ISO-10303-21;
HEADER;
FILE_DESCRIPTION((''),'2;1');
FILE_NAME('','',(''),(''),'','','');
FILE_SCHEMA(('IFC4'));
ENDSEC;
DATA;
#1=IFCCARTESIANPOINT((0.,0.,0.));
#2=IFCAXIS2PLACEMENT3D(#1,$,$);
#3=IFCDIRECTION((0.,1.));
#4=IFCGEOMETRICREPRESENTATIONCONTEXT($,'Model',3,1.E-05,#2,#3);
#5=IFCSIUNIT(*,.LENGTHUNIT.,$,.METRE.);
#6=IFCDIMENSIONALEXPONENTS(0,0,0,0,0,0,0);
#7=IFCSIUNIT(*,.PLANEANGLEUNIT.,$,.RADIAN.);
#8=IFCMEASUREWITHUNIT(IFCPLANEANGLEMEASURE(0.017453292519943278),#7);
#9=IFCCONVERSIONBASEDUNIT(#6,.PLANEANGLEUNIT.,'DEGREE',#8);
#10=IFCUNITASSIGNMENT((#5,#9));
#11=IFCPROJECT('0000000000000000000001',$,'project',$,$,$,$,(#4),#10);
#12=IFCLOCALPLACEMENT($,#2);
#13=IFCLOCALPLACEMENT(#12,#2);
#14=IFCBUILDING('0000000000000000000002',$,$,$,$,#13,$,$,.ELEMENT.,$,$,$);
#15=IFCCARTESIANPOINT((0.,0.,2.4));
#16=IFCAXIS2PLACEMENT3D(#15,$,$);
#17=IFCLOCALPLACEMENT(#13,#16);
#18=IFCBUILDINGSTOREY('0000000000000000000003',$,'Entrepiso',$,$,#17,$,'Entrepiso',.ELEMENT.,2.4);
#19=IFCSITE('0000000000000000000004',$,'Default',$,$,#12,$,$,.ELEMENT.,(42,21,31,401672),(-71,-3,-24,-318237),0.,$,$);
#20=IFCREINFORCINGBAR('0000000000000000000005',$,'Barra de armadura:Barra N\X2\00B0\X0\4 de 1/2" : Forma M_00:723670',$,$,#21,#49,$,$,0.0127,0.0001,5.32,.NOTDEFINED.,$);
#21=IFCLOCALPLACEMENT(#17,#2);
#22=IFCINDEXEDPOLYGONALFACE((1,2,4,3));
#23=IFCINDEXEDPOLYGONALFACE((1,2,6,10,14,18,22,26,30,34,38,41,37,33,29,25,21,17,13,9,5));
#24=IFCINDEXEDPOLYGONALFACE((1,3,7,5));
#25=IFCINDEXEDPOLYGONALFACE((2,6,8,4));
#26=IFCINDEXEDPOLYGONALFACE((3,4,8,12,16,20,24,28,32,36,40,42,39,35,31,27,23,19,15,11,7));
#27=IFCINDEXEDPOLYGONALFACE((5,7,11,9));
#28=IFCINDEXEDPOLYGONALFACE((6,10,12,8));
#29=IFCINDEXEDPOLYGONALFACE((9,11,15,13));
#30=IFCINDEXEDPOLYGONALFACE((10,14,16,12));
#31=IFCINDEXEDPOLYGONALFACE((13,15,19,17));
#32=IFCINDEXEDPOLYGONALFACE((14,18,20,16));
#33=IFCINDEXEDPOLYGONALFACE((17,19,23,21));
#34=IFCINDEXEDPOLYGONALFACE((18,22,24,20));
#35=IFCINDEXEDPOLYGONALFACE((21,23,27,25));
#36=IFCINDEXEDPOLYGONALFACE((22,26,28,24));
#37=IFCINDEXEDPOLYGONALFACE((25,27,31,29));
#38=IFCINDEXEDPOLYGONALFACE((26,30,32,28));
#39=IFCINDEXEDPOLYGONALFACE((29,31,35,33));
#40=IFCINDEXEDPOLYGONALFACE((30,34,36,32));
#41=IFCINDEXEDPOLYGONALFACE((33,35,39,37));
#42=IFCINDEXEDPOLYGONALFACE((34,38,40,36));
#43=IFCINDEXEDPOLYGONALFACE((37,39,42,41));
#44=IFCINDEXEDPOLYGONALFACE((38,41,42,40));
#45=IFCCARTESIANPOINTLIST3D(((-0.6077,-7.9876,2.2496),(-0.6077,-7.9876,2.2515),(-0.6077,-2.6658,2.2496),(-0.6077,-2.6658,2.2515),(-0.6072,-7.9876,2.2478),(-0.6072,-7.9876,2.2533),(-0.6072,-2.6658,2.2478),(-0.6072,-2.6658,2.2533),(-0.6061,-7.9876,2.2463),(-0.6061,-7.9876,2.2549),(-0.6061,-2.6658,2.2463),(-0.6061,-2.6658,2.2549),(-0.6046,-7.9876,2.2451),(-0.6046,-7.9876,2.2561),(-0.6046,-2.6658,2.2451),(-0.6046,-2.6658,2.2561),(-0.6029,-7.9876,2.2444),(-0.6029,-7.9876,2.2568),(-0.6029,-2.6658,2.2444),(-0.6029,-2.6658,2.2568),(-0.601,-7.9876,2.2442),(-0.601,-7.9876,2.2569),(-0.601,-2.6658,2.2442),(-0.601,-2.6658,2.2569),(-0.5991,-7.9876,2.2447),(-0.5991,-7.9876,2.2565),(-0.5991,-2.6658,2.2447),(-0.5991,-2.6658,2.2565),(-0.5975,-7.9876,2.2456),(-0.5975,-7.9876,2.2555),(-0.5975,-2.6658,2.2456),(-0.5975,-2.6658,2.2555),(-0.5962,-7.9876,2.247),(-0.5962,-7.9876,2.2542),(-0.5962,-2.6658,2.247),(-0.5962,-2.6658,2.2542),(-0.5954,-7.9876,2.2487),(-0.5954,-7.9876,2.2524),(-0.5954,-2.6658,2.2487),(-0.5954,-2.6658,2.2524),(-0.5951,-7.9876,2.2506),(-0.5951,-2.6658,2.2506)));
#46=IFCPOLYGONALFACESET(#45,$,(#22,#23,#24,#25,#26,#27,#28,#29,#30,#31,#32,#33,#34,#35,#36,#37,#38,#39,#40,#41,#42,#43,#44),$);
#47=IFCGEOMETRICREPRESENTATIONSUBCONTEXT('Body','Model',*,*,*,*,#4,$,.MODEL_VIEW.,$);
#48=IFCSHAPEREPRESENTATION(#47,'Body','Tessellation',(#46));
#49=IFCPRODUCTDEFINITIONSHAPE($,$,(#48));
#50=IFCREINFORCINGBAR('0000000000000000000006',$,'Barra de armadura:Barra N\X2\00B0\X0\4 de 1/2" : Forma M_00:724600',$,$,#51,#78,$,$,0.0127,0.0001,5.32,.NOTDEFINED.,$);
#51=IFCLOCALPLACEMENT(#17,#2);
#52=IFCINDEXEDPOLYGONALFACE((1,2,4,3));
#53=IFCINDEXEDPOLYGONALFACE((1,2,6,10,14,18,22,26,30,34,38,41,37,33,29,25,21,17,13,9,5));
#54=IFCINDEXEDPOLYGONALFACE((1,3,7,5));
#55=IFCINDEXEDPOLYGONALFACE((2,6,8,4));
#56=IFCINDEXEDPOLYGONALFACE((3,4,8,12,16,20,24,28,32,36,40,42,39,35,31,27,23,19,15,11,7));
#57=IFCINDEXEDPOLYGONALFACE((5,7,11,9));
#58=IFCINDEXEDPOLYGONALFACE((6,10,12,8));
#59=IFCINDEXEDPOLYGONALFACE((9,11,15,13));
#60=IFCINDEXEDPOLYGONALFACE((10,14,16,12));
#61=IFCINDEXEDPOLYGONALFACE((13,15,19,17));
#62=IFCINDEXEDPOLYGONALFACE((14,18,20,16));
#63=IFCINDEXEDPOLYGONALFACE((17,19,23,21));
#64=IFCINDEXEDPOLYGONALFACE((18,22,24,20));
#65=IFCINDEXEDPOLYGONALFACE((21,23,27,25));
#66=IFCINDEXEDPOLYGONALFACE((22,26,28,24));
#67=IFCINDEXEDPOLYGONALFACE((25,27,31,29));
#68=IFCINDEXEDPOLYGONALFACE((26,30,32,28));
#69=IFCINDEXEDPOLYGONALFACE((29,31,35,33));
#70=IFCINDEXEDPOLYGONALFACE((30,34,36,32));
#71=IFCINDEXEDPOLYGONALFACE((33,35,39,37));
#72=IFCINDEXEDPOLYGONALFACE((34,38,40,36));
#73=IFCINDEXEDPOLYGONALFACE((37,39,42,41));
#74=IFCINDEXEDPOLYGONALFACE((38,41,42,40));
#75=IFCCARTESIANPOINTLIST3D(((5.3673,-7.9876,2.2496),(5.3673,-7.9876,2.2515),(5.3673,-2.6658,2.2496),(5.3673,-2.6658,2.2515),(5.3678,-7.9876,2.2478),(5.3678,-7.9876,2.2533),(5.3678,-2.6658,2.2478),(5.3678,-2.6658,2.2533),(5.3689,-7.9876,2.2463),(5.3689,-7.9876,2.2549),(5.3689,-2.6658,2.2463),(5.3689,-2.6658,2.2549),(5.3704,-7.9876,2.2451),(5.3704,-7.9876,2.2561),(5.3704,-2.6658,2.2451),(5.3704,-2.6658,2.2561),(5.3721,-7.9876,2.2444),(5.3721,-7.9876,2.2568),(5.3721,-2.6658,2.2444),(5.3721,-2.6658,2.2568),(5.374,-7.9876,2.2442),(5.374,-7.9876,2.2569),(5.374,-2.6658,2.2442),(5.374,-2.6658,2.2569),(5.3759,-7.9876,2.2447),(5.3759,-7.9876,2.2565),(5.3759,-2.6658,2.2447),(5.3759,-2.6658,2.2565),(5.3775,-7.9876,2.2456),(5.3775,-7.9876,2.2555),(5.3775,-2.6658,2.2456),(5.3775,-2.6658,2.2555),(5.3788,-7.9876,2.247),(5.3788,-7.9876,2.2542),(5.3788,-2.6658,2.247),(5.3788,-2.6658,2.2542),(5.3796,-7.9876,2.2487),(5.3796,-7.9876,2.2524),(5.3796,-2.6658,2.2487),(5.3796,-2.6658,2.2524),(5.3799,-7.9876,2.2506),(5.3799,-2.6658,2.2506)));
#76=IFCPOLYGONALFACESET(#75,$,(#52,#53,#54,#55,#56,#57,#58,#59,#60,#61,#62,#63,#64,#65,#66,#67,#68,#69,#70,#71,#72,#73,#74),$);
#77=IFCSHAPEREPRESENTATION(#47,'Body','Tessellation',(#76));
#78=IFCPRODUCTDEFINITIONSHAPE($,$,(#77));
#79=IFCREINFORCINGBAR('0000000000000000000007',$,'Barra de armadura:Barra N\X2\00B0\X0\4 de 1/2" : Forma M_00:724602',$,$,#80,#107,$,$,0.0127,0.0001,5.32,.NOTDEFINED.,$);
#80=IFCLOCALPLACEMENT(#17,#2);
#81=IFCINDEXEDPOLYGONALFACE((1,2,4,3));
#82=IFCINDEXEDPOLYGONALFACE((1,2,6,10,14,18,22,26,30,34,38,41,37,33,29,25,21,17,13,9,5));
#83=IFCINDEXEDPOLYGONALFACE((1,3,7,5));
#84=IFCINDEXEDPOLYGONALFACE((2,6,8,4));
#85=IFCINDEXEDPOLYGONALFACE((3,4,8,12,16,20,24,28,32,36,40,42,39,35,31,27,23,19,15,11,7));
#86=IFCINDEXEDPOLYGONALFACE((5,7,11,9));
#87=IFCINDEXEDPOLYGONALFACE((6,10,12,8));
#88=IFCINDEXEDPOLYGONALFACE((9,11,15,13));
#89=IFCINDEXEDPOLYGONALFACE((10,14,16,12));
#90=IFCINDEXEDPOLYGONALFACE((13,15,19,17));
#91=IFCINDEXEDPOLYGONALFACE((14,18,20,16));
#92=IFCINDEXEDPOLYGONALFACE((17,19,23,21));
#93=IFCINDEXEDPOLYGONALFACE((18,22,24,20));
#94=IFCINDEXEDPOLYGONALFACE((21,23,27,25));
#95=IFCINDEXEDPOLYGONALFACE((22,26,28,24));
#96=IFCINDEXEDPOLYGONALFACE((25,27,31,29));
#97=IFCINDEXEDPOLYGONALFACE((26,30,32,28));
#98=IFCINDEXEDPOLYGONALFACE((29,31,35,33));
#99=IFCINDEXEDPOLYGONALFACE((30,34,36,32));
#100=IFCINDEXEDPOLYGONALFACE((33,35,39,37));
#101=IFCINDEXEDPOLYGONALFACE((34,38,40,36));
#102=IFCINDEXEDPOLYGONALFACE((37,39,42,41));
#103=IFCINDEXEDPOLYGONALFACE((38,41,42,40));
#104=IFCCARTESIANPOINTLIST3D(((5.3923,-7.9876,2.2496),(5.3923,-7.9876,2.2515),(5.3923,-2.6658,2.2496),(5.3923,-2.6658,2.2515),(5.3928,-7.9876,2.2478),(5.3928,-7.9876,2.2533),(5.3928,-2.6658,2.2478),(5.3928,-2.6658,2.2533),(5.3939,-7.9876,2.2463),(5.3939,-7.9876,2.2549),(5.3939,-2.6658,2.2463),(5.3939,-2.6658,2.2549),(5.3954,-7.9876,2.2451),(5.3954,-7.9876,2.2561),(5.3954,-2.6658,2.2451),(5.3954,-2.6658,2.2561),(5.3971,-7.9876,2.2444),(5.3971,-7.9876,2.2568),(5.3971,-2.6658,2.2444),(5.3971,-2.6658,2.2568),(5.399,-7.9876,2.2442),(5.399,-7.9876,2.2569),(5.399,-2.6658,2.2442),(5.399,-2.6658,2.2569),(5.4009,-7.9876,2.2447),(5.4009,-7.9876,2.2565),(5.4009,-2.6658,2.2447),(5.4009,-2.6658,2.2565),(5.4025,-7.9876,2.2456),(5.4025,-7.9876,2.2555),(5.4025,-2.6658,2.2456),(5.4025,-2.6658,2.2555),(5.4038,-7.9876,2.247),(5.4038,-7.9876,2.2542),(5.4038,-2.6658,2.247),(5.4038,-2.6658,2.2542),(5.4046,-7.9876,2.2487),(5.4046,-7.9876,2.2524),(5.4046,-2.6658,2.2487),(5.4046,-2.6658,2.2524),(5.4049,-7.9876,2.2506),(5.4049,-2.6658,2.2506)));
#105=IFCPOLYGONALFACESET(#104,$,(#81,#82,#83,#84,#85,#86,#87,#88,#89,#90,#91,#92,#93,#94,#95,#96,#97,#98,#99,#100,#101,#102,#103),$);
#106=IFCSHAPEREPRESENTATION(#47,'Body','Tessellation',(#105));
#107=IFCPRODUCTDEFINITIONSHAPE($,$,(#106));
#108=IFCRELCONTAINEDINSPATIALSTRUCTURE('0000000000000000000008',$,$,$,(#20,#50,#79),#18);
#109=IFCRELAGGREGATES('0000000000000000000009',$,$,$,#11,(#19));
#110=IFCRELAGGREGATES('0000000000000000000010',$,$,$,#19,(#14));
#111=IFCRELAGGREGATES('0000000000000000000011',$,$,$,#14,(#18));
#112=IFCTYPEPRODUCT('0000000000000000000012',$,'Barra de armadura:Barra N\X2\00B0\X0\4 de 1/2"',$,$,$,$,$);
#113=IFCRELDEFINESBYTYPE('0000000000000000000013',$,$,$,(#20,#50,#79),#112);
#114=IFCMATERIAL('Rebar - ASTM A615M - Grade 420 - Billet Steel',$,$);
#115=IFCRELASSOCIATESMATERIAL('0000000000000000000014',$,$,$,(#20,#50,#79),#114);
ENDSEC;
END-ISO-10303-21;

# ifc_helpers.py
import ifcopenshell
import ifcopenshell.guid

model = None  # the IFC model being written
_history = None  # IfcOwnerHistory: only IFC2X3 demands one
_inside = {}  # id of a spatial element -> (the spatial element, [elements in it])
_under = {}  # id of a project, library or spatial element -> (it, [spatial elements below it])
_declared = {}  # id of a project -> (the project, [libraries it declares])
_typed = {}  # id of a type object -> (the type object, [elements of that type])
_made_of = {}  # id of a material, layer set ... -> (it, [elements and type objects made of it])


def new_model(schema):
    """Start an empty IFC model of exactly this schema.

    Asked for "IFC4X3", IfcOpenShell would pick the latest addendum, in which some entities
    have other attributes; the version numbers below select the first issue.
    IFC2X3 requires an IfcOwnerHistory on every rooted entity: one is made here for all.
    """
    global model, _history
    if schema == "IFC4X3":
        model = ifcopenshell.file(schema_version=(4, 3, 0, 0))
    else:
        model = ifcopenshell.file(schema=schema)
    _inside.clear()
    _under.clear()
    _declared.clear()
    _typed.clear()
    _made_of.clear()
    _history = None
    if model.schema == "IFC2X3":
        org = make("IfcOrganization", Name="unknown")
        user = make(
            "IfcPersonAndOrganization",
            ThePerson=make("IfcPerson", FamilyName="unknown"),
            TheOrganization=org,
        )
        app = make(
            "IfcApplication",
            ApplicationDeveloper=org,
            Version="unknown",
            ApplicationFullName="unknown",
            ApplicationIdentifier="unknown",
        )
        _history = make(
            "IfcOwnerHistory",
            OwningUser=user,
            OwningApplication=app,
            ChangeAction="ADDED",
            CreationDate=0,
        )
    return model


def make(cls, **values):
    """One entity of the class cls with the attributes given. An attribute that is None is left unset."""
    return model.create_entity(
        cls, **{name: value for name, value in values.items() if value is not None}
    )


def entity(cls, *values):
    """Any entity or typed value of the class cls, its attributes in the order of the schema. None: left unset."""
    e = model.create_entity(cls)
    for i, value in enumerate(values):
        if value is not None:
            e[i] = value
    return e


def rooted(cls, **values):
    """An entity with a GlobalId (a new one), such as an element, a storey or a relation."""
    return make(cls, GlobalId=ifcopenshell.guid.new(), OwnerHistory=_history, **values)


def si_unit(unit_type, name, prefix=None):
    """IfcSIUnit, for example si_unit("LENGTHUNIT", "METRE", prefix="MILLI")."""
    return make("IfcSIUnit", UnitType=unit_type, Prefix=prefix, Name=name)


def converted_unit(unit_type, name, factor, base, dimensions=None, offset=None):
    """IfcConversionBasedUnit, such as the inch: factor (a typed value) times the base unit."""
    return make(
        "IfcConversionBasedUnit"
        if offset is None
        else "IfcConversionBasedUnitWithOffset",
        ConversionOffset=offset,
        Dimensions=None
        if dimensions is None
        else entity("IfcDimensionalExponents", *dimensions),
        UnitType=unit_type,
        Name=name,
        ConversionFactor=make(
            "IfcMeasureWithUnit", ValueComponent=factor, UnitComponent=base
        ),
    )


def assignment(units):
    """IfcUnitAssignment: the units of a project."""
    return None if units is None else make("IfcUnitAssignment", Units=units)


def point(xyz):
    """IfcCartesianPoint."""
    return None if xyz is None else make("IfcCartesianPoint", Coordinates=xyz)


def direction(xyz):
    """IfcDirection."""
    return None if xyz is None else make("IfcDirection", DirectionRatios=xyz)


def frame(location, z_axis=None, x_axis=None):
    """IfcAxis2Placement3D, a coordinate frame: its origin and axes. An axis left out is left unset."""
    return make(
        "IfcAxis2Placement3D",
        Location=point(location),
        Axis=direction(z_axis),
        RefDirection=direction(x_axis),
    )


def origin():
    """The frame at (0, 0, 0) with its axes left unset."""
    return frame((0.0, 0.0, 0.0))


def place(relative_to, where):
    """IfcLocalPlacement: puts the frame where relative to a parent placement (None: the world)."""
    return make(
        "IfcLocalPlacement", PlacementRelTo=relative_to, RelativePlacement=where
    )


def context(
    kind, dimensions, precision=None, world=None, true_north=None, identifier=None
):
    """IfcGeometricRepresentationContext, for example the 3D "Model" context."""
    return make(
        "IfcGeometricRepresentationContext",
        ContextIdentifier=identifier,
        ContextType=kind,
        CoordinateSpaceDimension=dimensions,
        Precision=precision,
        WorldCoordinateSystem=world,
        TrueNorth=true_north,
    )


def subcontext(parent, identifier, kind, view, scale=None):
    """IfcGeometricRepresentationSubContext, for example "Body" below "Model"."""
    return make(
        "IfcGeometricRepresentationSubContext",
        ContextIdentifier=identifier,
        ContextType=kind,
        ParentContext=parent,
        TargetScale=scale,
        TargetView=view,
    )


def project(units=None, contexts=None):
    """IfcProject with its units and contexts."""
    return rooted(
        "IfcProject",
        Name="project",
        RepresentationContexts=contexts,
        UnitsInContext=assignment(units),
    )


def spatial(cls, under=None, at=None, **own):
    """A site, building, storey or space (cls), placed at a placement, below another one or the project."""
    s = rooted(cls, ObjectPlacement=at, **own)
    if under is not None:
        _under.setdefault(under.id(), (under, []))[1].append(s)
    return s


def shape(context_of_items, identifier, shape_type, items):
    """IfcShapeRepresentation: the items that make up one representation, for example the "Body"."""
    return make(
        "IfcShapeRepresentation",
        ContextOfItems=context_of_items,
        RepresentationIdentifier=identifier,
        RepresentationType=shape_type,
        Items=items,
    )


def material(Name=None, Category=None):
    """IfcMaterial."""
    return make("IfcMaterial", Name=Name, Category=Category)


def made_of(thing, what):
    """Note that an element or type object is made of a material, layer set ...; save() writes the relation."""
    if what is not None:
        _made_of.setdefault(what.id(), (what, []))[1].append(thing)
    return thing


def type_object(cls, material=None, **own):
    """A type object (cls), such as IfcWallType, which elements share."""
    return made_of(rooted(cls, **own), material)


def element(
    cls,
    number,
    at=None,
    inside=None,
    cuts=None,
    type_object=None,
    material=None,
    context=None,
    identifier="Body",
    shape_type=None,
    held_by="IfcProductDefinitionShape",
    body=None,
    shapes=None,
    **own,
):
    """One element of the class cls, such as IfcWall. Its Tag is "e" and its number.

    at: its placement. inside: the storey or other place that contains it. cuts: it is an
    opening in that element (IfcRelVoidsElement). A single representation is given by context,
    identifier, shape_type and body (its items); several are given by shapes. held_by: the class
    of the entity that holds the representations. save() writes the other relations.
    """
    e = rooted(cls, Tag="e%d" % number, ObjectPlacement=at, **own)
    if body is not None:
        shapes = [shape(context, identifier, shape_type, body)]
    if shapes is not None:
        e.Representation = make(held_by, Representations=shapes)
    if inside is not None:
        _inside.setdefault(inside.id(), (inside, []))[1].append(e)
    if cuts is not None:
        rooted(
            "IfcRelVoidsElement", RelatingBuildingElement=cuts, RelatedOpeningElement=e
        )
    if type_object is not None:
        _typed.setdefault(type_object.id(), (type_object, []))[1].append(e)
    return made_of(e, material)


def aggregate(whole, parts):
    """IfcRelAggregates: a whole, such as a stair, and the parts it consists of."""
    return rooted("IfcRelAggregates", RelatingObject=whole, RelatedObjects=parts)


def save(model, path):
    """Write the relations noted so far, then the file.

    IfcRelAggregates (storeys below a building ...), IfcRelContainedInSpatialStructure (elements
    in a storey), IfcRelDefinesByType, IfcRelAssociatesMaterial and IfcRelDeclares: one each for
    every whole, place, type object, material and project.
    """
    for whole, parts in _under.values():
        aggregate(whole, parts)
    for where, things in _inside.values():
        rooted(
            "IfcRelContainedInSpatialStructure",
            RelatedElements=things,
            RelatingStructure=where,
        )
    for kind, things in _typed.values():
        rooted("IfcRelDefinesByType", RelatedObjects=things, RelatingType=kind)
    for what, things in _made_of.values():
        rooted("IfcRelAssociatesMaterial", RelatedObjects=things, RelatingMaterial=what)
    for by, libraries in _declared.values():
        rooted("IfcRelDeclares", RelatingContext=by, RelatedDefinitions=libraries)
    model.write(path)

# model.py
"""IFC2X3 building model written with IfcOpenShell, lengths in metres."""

from ifc_helpers import new_model, entity, si_unit, converted_unit, direction, frame, origin, place, context, subcontext, project, spatial, material, type_object, element, save


model = new_model("IFC2X3")

# Units and contexts
model_context = context("Model", 3, precision=1e-05, world=origin(), true_north=direction((0.0, 1.0)))
body_context = subcontext(model_context, "Body", "Model", "MODEL_VIEW")
ifc_project = project(units=[si_unit("LENGTHUNIT", "METRE"), converted_unit("PLANEANGLEUNIT", "DEGREE", entity("IfcPlaneAngleMeasure", 0.017453292519943278), si_unit("PLANEANGLEUNIT", "RADIAN"), dimensions=[0, 0, 0, 0, 0, 0, 0])], contexts=[model_context])

# Site, building, storey
site_placement = place(None, origin())
site = spatial("IfcSite", under=ifc_project, at=site_placement, Name="Default", CompositionType="ELEMENT", RefLatitude=(42, 21, 31, 401672), RefLongitude=(-71, -3, -24, -318237), RefElevation=0.0)
building_placement = place(site_placement, origin())
building = spatial("IfcBuilding", under=site, at=building_placement, CompositionType="ELEMENT")
storey_placement = place(building_placement, frame((0.0, 0.0, 2.4)))
storey = spatial("IfcBuildingStorey", under=building, at=storey_placement, Name="Entrepiso", LongName="Entrepiso", CompositionType="ELEMENT", Elevation=2.4)

# Reinforcing bars
ifc_material = material(Name="Rebar - ASTM A615M - Grade 420 - Billet Steel")
type_product_1 = type_object("IfcTypeProduct", Name="Barra de armadura:Barra N°4 de 1/2\"")
reinforcing_bar_1_placement = place(storey_placement, origin())
element("IfcReinforcingBar", 1, at=reinforcing_bar_1_placement, inside=storey, type_object=type_product_1, material=ifc_material, Name="Barra de armadura:Barra N°4 de 1/2\" : Forma M_00:723670", BarLength=5.32, BarRole="NOTDEFINED", CrossSectionArea=0.0001, NominalDiameter=0.0127, context=body_context, shape_type="AdvancedSweptSolid", body=[
    entity("IfcSweptDiskSolid", entity("IfcCompositeCurve", [entity("IfcCompositeCurveSegment", "CONTINUOUS", True, entity("IfcPolyline", [entity("IfcCartesianPoint", [-0.6014, -7.9876, 2.2506]), entity("IfcCartesianPoint", [-0.6014, -2.6658, 2.2506])]))], False), 0.0063, None, 0.0, 1.0),
])
reinforcing_bar_2_placement = place(storey_placement, origin())
element("IfcReinforcingBar", 2, at=reinforcing_bar_2_placement, inside=storey, type_object=type_product_1, material=ifc_material, Name="Barra de armadura:Barra N°4 de 1/2\" : Forma M_00:724600", BarLength=5.32, BarRole="NOTDEFINED", CrossSectionArea=0.0001, NominalDiameter=0.0127, context=body_context, shape_type="AdvancedSweptSolid", body=[
    entity("IfcSweptDiskSolid", entity("IfcCompositeCurve", [entity("IfcCompositeCurveSegment", "CONTINUOUS", True, entity("IfcPolyline", [entity("IfcCartesianPoint", [5.3736, -7.9876, 2.2506]), entity("IfcCartesianPoint", [5.3736, -2.6658, 2.2506])]))], False), 0.0063, None, 0.0, 1.0),
])
reinforcing_bar_3_placement = place(storey_placement, origin())
element("IfcReinforcingBar", 3, at=reinforcing_bar_3_placement, inside=storey, type_object=type_product_1, material=ifc_material, Name="Barra de armadura:Barra N°4 de 1/2\" : Forma M_00:724602", BarLength=5.32, BarRole="NOTDEFINED", CrossSectionArea=0.0001, NominalDiameter=0.0127, context=body_context, shape_type="AdvancedSweptSolid", body=[
    entity("IfcSweptDiskSolid", entity("IfcCompositeCurve", [entity("IfcCompositeCurveSegment", "CONTINUOUS", True, entity("IfcPolyline", [entity("IfcCartesianPoint", [5.3986, -7.9876, 2.2506]), entity("IfcCartesianPoint", [5.3986, -2.6658, 2.2506])]))], False), 0.0063, None, 0.0, 1.0),
])

save(model, "model.ifc")
